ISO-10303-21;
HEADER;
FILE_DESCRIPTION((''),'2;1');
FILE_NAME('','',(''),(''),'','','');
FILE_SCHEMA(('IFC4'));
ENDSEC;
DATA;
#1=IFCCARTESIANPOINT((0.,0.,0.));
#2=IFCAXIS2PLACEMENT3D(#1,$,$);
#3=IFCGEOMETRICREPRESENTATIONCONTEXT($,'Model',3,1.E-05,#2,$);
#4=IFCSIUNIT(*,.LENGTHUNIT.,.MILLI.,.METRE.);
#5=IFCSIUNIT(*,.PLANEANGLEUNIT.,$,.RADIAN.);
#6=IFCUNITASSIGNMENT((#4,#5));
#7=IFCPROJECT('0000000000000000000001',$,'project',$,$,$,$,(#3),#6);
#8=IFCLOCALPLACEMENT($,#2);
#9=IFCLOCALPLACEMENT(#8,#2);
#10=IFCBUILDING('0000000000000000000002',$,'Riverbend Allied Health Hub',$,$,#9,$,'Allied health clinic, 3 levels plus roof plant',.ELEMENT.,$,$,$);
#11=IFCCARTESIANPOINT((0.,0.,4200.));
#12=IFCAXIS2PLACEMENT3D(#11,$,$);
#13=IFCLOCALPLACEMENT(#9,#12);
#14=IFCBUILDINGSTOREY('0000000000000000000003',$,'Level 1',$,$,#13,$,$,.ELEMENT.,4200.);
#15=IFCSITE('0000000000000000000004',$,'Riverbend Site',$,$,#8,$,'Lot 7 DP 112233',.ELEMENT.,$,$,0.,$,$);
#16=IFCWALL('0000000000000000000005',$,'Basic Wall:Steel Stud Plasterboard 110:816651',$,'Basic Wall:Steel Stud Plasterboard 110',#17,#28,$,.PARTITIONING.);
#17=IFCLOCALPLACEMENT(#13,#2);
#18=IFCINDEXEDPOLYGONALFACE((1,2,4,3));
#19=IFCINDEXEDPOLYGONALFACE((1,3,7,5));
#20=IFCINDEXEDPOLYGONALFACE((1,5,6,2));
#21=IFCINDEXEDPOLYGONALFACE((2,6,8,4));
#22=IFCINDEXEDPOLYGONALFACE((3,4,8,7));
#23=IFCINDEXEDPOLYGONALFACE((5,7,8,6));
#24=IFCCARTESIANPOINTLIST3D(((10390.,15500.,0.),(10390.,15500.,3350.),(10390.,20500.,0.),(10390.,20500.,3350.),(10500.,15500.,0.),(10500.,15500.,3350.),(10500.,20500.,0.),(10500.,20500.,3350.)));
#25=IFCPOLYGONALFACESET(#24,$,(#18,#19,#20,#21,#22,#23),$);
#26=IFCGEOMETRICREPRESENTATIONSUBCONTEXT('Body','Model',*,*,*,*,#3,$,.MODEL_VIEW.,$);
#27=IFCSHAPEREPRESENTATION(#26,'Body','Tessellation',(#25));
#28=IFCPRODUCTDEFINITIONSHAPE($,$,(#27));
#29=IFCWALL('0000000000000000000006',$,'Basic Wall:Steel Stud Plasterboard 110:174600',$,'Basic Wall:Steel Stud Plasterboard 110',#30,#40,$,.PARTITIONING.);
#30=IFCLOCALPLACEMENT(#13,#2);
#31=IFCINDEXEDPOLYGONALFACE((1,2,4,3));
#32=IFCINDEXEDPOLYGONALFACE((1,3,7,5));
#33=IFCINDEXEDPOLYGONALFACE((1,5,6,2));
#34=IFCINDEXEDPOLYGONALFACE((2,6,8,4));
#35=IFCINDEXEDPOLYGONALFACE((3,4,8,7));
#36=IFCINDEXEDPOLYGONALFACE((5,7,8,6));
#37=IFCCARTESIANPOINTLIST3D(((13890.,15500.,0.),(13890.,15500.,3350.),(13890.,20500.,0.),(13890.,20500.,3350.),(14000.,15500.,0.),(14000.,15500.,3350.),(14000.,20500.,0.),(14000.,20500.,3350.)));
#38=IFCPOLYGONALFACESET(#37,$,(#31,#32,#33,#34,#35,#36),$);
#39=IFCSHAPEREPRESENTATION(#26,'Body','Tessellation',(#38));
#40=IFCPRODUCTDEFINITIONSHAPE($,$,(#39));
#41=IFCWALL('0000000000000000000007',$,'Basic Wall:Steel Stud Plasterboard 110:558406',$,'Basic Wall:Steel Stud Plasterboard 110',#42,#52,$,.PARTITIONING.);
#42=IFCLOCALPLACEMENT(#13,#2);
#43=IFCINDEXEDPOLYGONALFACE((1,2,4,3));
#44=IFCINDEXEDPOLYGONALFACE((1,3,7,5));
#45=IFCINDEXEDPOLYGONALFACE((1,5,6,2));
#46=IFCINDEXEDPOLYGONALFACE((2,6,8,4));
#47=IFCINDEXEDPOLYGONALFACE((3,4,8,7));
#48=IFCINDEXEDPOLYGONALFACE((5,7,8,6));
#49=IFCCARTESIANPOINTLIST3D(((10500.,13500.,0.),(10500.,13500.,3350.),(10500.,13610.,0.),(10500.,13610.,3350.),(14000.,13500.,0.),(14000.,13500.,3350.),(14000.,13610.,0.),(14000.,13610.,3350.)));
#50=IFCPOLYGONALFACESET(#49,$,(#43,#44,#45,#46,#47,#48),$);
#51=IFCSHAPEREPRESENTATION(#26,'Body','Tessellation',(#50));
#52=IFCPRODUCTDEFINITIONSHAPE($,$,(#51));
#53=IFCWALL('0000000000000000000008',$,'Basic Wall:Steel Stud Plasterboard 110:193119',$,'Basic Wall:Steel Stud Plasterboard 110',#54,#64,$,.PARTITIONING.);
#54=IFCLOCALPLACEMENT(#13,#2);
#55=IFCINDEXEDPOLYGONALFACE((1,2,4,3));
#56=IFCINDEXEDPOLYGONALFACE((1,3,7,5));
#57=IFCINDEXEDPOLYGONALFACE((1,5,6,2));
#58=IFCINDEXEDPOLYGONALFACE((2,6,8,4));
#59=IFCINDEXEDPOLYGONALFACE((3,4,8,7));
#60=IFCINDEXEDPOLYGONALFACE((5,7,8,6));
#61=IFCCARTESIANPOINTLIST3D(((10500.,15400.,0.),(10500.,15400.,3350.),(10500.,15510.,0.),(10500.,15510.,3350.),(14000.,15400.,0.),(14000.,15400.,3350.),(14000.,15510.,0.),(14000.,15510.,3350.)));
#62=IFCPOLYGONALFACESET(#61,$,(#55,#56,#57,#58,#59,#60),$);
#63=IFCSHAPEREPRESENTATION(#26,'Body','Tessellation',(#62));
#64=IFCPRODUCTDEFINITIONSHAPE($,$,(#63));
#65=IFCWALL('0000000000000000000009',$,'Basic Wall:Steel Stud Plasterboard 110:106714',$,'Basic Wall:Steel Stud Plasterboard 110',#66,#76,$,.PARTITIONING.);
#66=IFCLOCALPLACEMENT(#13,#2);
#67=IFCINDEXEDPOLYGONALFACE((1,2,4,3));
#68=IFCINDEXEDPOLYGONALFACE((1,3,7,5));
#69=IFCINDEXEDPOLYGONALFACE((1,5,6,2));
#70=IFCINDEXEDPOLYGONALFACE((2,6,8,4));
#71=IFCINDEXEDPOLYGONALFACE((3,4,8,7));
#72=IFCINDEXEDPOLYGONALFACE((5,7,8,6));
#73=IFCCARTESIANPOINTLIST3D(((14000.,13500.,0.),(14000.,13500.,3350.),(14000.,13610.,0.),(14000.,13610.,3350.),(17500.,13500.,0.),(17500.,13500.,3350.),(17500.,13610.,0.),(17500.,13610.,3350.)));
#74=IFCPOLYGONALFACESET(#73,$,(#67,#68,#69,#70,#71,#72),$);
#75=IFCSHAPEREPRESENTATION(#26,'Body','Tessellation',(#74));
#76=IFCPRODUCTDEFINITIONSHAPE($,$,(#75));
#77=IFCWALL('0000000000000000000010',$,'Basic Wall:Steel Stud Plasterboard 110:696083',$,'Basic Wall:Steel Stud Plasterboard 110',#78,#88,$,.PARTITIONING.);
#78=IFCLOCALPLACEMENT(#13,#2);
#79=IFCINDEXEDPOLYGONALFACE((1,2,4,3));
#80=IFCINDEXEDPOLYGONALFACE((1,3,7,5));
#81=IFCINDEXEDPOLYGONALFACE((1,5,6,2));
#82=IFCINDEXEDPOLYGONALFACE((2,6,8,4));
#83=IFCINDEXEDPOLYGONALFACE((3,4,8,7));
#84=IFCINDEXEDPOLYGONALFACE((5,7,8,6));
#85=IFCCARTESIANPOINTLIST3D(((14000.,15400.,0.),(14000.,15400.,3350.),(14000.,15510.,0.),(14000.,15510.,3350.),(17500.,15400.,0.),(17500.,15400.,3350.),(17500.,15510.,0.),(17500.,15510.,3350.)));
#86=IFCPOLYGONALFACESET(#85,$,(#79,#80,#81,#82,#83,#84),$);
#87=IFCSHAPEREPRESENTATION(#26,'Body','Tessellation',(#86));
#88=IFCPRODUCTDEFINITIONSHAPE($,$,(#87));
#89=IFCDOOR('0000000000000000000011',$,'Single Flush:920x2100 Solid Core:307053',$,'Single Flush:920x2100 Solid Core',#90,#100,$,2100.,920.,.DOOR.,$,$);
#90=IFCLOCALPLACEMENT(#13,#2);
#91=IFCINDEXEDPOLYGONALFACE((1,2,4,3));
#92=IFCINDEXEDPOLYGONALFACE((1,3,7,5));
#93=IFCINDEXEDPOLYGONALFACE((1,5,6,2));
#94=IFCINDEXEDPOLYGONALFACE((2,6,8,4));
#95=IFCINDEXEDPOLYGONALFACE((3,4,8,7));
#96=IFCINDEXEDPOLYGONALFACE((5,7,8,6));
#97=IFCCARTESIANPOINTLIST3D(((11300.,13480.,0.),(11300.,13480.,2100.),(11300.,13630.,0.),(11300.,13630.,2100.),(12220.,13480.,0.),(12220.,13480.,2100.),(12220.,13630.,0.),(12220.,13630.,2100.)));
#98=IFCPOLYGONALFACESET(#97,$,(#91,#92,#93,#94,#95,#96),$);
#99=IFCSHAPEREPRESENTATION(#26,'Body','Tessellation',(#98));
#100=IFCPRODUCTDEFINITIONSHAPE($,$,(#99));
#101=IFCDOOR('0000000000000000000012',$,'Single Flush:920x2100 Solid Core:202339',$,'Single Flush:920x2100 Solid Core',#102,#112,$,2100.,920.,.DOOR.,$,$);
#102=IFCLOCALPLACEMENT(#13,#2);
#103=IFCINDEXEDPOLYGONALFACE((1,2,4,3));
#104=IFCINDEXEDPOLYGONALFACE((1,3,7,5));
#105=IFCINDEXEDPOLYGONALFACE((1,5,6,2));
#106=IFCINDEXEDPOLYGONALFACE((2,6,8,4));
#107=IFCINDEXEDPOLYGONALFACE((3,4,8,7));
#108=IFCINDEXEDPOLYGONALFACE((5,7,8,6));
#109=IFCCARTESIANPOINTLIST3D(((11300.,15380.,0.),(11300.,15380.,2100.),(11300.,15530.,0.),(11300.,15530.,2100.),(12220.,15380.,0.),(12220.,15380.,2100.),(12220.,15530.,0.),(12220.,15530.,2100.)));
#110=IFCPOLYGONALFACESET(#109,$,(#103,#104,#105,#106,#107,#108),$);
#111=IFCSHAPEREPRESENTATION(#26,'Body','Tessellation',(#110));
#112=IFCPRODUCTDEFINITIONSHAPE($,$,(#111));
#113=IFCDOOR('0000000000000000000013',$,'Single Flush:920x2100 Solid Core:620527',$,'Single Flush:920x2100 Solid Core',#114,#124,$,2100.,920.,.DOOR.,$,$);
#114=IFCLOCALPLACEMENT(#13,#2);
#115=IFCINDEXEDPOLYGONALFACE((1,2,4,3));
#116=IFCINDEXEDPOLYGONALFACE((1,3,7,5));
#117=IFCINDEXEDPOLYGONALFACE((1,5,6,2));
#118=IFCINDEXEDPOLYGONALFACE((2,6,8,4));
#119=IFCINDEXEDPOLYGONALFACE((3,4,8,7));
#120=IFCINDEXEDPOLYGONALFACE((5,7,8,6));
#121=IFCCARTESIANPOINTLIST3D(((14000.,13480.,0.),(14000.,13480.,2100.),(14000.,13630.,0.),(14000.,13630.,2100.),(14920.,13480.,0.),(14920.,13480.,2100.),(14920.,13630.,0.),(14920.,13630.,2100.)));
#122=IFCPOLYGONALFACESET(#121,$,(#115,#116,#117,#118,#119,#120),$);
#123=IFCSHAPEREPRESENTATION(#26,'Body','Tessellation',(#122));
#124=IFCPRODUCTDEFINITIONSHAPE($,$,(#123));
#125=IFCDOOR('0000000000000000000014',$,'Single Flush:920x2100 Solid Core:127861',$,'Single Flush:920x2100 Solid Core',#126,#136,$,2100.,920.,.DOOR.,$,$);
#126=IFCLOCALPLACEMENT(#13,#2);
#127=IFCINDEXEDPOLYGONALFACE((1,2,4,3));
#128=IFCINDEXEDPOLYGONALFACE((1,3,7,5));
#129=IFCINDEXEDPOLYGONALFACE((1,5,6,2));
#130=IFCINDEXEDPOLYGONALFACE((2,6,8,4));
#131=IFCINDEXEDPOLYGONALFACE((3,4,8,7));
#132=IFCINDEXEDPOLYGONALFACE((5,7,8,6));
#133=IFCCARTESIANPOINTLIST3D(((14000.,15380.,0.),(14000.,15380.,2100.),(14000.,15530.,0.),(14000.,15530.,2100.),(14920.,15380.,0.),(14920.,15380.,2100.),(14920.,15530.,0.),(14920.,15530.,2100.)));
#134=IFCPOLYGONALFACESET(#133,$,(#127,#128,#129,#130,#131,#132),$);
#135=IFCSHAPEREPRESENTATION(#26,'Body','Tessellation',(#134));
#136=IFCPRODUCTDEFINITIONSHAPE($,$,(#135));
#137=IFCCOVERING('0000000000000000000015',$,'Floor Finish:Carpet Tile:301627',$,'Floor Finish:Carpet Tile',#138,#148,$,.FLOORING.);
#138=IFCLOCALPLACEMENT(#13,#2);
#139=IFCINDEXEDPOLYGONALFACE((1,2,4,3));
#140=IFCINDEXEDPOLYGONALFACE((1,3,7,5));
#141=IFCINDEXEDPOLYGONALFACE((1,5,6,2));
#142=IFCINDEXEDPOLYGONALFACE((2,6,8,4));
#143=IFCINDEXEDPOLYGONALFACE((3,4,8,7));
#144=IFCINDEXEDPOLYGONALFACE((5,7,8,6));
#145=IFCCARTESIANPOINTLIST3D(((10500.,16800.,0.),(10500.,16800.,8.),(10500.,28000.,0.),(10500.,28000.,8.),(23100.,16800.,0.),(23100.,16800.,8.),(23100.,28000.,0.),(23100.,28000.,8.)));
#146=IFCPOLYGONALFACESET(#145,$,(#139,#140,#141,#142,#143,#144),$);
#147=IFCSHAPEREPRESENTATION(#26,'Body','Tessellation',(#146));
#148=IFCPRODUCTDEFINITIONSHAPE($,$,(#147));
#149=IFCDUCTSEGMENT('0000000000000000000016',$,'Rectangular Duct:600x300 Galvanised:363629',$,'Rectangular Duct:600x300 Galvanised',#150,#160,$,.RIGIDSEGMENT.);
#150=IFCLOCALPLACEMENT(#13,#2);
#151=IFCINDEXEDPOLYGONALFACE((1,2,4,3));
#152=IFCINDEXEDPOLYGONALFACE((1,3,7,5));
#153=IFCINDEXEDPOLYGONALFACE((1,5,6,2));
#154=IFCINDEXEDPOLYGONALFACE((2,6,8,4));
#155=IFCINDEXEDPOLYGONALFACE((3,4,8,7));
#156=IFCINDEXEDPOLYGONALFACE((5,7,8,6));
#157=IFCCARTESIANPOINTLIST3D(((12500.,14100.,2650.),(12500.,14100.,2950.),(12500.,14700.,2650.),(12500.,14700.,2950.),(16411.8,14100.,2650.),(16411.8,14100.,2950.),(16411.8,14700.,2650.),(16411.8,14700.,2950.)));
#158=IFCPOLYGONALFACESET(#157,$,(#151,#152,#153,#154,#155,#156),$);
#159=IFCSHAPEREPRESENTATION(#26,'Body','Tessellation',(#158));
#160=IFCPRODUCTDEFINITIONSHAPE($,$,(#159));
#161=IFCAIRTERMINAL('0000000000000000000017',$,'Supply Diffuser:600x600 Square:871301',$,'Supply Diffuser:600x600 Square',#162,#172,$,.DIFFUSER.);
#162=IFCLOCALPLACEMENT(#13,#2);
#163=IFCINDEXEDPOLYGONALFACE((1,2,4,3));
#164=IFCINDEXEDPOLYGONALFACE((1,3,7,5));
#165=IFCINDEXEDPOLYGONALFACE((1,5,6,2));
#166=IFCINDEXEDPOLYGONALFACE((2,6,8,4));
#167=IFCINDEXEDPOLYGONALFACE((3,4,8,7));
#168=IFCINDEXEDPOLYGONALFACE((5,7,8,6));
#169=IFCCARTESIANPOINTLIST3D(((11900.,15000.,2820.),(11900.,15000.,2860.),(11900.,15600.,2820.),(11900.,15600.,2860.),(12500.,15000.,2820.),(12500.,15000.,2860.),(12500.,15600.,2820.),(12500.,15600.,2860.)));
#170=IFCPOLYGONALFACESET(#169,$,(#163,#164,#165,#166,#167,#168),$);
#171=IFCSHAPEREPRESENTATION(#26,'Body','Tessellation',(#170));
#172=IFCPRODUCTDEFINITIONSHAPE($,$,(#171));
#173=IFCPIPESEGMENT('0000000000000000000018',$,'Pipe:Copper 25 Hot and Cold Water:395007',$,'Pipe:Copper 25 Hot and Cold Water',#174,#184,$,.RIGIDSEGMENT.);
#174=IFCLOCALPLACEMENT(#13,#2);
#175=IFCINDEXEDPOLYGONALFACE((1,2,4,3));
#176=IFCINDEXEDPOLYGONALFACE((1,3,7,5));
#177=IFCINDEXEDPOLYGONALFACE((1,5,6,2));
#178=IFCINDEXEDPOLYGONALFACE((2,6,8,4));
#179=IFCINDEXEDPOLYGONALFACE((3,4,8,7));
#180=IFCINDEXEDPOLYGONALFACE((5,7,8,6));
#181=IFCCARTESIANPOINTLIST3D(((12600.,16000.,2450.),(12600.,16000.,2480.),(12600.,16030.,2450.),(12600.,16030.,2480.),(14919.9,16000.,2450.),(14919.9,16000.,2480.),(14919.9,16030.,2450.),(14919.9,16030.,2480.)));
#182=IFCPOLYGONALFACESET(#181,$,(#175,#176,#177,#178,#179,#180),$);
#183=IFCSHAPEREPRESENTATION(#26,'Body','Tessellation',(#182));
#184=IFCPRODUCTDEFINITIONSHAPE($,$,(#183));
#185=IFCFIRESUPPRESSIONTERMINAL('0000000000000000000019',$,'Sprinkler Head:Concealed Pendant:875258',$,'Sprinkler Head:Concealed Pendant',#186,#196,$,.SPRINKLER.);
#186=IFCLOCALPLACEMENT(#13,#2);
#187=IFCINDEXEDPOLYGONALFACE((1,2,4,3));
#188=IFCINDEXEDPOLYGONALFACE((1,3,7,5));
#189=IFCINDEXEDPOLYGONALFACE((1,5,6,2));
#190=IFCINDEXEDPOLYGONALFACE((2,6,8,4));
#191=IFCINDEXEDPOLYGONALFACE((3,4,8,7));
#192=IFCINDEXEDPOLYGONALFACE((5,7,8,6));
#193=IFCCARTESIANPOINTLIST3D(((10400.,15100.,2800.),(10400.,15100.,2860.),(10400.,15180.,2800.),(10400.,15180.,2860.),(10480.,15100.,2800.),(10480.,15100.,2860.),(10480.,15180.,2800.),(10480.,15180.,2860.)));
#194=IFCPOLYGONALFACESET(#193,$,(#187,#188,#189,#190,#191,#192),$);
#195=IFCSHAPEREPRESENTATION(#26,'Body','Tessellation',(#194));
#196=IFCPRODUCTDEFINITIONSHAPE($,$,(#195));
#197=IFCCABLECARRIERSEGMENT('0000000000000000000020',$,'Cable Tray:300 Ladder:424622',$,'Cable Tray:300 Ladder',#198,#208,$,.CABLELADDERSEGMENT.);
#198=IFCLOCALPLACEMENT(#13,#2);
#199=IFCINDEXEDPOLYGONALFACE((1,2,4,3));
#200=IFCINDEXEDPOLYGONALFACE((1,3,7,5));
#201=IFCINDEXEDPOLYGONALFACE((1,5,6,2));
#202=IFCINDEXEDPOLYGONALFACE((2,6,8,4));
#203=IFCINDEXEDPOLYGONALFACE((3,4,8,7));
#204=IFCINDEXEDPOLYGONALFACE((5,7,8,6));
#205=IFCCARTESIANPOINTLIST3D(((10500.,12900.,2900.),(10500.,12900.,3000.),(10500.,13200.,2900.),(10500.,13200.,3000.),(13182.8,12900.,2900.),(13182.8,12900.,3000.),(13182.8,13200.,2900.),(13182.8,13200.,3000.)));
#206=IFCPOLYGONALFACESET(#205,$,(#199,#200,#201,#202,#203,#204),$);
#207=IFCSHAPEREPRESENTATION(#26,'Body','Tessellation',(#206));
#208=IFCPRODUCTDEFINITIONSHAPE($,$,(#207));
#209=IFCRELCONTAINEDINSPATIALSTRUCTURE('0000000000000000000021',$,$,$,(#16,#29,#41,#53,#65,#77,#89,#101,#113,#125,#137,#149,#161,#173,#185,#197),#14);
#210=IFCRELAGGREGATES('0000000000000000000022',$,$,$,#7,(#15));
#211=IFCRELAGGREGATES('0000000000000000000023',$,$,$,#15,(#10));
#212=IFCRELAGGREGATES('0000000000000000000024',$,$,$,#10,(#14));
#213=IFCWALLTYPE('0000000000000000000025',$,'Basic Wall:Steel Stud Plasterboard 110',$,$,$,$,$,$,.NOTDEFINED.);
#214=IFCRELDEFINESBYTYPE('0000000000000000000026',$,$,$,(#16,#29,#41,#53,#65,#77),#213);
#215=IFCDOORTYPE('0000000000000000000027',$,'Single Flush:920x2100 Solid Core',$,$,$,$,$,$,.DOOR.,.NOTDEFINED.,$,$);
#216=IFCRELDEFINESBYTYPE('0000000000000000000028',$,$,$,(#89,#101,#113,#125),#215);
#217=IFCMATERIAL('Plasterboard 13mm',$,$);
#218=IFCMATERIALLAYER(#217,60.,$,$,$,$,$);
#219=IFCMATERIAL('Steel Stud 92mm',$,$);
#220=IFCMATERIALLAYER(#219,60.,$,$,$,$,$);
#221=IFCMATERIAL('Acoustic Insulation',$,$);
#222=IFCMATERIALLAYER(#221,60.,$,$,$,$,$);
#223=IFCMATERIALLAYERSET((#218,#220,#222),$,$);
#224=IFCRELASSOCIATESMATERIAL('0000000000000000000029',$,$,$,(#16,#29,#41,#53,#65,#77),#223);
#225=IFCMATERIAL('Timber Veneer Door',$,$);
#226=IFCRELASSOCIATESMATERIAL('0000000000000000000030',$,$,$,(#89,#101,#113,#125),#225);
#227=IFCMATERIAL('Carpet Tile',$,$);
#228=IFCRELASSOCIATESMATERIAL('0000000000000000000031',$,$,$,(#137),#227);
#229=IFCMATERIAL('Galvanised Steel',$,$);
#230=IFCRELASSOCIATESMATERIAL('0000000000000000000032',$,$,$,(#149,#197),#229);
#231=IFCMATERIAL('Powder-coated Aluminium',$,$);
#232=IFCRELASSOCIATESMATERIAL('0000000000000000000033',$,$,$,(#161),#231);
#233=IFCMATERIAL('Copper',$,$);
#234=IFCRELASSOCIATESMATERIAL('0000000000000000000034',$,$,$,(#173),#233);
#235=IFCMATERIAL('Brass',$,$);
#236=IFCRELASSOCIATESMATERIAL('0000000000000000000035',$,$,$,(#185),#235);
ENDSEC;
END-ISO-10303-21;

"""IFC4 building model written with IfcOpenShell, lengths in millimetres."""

from ifc_helpers import new_model, si_unit, frame, frame_2d, origin, place, context, subcontext, project, spatial, rectangle, extrude, material, layer, layer_set, layer_usage, type_object, element, save


model = new_model("IFC4")

# Units and contexts
model_context = context("Model", 3, precision=1e-05, world=origin())
body_context = subcontext(model_context, "Body", "Model", "MODEL_VIEW")
ifc_project = project(units=[si_unit("LENGTHUNIT", "METRE", prefix="MILLI"), si_unit("PLANEANGLEUNIT", "RADIAN")], contexts=[model_context])

# Site, building, storey
site_placement = place(None, origin())
site = spatial("IfcSite", under=ifc_project, at=site_placement, Name="Riverbend Site", LongName="Lot 7 DP 112233", CompositionType="ELEMENT", RefElevation=0.0)
building_placement = place(site_placement, origin())
building = spatial("IfcBuilding", under=site, at=building_placement, Name="Riverbend Allied Health Hub", LongName="Allied health clinic, 3 levels plus roof plant", CompositionType="ELEMENT")
storey_placement = place(building_placement, frame((0.0, 0.0, 4200.0)))
storey = spatial("IfcBuildingStorey", under=building, at=storey_placement, Name="Level 1", CompositionType="ELEMENT", Elevation=4200.0)

# Walls
ifc_material_1 = material(Name="Plasterboard 13mm")
ifc_layer_1 = layer(ifc_material_1, 60.0)
ifc_material_2 = material(Name="Steel Stud 92mm")
ifc_layer_2 = layer(ifc_material_2, 60.0)
ifc_material_3 = material(Name="Acoustic Insulation")
ifc_layer_3 = layer(ifc_material_3, 60.0)
ifc_layer_set = layer_set([ifc_layer_1, ifc_layer_2, ifc_layer_3])
ifc_layer_usage = layer_usage(ifc_layer_set, "AXIS2", "POSITIVE", 0.0)
wall_type = type_object("IfcWallType", Name="Basic Wall:Steel Stud Plasterboard 110", PredefinedType="NOTDEFINED")
for number, where, z_axis, x_axis, name in (
    (1, (10500.0, 15500.0, 0.0), (0.0, 0.0, 1.0), (0.0, 1.0, 0.0), "Basic Wall:Steel Stud Plasterboard 110:816651"),
    (2, (14000.0, 15500.0, 0.0), (0.0, 0.0, 1.0), (0.0, 1.0, 0.0), "Basic Wall:Steel Stud Plasterboard 110:174600"),
):
    element("IfcWall", number, at=place(storey_placement, frame(where, z_axis=z_axis, x_axis=x_axis)), inside=storey, type_object=wall_type, material=ifc_layer_usage, Name=name, ObjectType="Basic Wall:Steel Stud Plasterboard 110", PredefinedType="PARTITIONING", context=body_context, shape_type="SweptSolid", body=[
        extrude(rectangle(XDim=5000.0, YDim=110.0, at=frame_2d((2500.0, 55.0))), origin(), (0.0, 0.0, 1.0), 3350.0),
    ])
for number, where, name in (
    (3, (10500.0, 13500.0, 0.0), "Basic Wall:Steel Stud Plasterboard 110:558406"),
    (4, (10500.0, 15400.0, 0.0), "Basic Wall:Steel Stud Plasterboard 110:193119"),
    (5, (14000.0, 13500.0, 0.0), "Basic Wall:Steel Stud Plasterboard 110:106714"),
    (6, (14000.0, 15400.0, 0.0), "Basic Wall:Steel Stud Plasterboard 110:696083"),
):
    element("IfcWall", number, at=place(storey_placement, frame(where)), inside=storey, type_object=wall_type, material=ifc_layer_usage, Name=name, ObjectType="Basic Wall:Steel Stud Plasterboard 110", PredefinedType="PARTITIONING", context=body_context, shape_type="SweptSolid", body=[
        extrude(rectangle(XDim=3500.0, YDim=110.0, at=frame_2d((1750.0, 55.0))), origin(), (0.0, 0.0, 1.0), 3350.0),
    ])

# Doors
ifc_material_4 = material(Name="Timber Veneer Door")
door_type = type_object("IfcDoorType", Name="Single Flush:920x2100 Solid Core", OperationType="NOTDEFINED", PredefinedType="DOOR")
for number, where, name in (
    (7, (11300.0, 13480.0, 0.0), "Single Flush:920x2100 Solid Core:307053"),
    (8, (11300.0, 15380.0, 0.0), "Single Flush:920x2100 Solid Core:202339"),
    (9, (14000.0, 13480.0, 0.0), "Single Flush:920x2100 Solid Core:620527"),
    (10, (14000.0, 15380.0, 0.0), "Single Flush:920x2100 Solid Core:127861"),
):
    element("IfcDoor", number, at=place(storey_placement, frame(where)), inside=storey, type_object=door_type, material=ifc_material_4, Name=name, ObjectType="Single Flush:920x2100 Solid Core", OverallHeight=2100.0, OverallWidth=920.0, PredefinedType="DOOR", context=body_context, shape_type="SweptSolid", body=[
        extrude(rectangle(XDim=920.0, YDim=150.0, at=frame_2d((460.0, 75.0))), origin(), (0.0, 0.0, 1.0), 2100.0),
    ])

# Covering
ifc_material_5 = material(Name="Carpet Tile")
covering_placement = place(storey_placement, frame((10500.0, 16800.0, 0.0)))
element("IfcCovering", 11, at=covering_placement, inside=storey, material=ifc_material_5, Name="Floor Finish:Carpet Tile:301627", ObjectType="Floor Finish:Carpet Tile", PredefinedType="FLOORING", context=body_context, shape_type="SweptSolid", body=[
    extrude(rectangle(XDim=12600.0, YDim=11200.0, at=frame_2d((6300.0, 5600.0))), origin(), (0.0, 0.0, 1.0), 8.0),
])

# Duct segment
ifc_material_6 = material(Name="Galvanised Steel")
duct_segment_placement = place(storey_placement, frame((12500.0, 14100.0, 2650.0)))
element("IfcDuctSegment", 12, at=duct_segment_placement, inside=storey, material=ifc_material_6, Name="Rectangular Duct:600x300 Galvanised:363629", ObjectType="Rectangular Duct:600x300 Galvanised", PredefinedType="RIGIDSEGMENT", context=body_context, shape_type="SweptSolid", body=[
    extrude(rectangle(XDim=3911.8, YDim=600.0, at=frame_2d((1955.9, 300.0))), origin(), (0.0, 0.0, 1.0), 300.0),
])

# Air terminal
ifc_material_7 = material(Name="Powder-coated Aluminium")
air_terminal_placement = place(storey_placement, frame((11900.0, 15000.0, 2820.0)))
element("IfcAirTerminal", 13, at=air_terminal_placement, inside=storey, material=ifc_material_7, Name="Supply Diffuser:600x600 Square:871301", ObjectType="Supply Diffuser:600x600 Square", PredefinedType="DIFFUSER", context=body_context, shape_type="SweptSolid", body=[
    extrude(rectangle(XDim=600.0, YDim=600.0, at=frame_2d((300.0, 300.0))), origin(), (0.0, 0.0, 1.0), 40.0),
])

# Pipe segment
ifc_material_8 = material(Name="Copper")
pipe_segment_placement = place(storey_placement, frame((12600.0, 16000.0, 2450.0)))
element("IfcPipeSegment", 14, at=pipe_segment_placement, inside=storey, material=ifc_material_8, Name="Pipe:Copper 25 Hot and Cold Water:395007", ObjectType="Pipe:Copper 25 Hot and Cold Water", PredefinedType="RIGIDSEGMENT", context=body_context, shape_type="SweptSolid", body=[
    extrude(rectangle(XDim=2319.9, YDim=30.0, at=frame_2d((1160.0, 15.0))), origin(), (0.0, 0.0, 1.0), 30.0),
])

# Fire suppression terminal
ifc_material_9 = material(Name="Brass")
fire_suppression_terminal_placement = place(storey_placement, frame((10400.0, 15100.0, 2800.0)))
element("IfcFireSuppressionTerminal", 15, at=fire_suppression_terminal_placement, inside=storey, material=ifc_material_9, Name="Sprinkler Head:Concealed Pendant:875258", ObjectType="Sprinkler Head:Concealed Pendant", PredefinedType="SPRINKLER", context=body_context, shape_type="SweptSolid", body=[
    extrude(rectangle(XDim=80.0, YDim=80.0, at=frame_2d((40.0, 40.0))), origin(), (0.0, 0.0, 1.0), 60.0),
])

# Cable carrier segment
cable_carrier_segment_placement = place(storey_placement, frame((10500.0, 12900.0, 2900.0)))
element("IfcCableCarrierSegment", 16, at=cable_carrier_segment_placement, inside=storey, material=ifc_material_6, Name="Cable Tray:300 Ladder:424622", ObjectType="Cable Tray:300 Ladder", PredefinedType="CABLELADDERSEGMENT", context=body_context, shape_type="SweptSolid", body=[
    extrude(rectangle(XDim=2682.8, YDim=300.0, at=frame_2d((1341.4, 150.0))), origin(), (0.0, 0.0, 1.0), 100.0),
])

save(model, "model.ifc")
